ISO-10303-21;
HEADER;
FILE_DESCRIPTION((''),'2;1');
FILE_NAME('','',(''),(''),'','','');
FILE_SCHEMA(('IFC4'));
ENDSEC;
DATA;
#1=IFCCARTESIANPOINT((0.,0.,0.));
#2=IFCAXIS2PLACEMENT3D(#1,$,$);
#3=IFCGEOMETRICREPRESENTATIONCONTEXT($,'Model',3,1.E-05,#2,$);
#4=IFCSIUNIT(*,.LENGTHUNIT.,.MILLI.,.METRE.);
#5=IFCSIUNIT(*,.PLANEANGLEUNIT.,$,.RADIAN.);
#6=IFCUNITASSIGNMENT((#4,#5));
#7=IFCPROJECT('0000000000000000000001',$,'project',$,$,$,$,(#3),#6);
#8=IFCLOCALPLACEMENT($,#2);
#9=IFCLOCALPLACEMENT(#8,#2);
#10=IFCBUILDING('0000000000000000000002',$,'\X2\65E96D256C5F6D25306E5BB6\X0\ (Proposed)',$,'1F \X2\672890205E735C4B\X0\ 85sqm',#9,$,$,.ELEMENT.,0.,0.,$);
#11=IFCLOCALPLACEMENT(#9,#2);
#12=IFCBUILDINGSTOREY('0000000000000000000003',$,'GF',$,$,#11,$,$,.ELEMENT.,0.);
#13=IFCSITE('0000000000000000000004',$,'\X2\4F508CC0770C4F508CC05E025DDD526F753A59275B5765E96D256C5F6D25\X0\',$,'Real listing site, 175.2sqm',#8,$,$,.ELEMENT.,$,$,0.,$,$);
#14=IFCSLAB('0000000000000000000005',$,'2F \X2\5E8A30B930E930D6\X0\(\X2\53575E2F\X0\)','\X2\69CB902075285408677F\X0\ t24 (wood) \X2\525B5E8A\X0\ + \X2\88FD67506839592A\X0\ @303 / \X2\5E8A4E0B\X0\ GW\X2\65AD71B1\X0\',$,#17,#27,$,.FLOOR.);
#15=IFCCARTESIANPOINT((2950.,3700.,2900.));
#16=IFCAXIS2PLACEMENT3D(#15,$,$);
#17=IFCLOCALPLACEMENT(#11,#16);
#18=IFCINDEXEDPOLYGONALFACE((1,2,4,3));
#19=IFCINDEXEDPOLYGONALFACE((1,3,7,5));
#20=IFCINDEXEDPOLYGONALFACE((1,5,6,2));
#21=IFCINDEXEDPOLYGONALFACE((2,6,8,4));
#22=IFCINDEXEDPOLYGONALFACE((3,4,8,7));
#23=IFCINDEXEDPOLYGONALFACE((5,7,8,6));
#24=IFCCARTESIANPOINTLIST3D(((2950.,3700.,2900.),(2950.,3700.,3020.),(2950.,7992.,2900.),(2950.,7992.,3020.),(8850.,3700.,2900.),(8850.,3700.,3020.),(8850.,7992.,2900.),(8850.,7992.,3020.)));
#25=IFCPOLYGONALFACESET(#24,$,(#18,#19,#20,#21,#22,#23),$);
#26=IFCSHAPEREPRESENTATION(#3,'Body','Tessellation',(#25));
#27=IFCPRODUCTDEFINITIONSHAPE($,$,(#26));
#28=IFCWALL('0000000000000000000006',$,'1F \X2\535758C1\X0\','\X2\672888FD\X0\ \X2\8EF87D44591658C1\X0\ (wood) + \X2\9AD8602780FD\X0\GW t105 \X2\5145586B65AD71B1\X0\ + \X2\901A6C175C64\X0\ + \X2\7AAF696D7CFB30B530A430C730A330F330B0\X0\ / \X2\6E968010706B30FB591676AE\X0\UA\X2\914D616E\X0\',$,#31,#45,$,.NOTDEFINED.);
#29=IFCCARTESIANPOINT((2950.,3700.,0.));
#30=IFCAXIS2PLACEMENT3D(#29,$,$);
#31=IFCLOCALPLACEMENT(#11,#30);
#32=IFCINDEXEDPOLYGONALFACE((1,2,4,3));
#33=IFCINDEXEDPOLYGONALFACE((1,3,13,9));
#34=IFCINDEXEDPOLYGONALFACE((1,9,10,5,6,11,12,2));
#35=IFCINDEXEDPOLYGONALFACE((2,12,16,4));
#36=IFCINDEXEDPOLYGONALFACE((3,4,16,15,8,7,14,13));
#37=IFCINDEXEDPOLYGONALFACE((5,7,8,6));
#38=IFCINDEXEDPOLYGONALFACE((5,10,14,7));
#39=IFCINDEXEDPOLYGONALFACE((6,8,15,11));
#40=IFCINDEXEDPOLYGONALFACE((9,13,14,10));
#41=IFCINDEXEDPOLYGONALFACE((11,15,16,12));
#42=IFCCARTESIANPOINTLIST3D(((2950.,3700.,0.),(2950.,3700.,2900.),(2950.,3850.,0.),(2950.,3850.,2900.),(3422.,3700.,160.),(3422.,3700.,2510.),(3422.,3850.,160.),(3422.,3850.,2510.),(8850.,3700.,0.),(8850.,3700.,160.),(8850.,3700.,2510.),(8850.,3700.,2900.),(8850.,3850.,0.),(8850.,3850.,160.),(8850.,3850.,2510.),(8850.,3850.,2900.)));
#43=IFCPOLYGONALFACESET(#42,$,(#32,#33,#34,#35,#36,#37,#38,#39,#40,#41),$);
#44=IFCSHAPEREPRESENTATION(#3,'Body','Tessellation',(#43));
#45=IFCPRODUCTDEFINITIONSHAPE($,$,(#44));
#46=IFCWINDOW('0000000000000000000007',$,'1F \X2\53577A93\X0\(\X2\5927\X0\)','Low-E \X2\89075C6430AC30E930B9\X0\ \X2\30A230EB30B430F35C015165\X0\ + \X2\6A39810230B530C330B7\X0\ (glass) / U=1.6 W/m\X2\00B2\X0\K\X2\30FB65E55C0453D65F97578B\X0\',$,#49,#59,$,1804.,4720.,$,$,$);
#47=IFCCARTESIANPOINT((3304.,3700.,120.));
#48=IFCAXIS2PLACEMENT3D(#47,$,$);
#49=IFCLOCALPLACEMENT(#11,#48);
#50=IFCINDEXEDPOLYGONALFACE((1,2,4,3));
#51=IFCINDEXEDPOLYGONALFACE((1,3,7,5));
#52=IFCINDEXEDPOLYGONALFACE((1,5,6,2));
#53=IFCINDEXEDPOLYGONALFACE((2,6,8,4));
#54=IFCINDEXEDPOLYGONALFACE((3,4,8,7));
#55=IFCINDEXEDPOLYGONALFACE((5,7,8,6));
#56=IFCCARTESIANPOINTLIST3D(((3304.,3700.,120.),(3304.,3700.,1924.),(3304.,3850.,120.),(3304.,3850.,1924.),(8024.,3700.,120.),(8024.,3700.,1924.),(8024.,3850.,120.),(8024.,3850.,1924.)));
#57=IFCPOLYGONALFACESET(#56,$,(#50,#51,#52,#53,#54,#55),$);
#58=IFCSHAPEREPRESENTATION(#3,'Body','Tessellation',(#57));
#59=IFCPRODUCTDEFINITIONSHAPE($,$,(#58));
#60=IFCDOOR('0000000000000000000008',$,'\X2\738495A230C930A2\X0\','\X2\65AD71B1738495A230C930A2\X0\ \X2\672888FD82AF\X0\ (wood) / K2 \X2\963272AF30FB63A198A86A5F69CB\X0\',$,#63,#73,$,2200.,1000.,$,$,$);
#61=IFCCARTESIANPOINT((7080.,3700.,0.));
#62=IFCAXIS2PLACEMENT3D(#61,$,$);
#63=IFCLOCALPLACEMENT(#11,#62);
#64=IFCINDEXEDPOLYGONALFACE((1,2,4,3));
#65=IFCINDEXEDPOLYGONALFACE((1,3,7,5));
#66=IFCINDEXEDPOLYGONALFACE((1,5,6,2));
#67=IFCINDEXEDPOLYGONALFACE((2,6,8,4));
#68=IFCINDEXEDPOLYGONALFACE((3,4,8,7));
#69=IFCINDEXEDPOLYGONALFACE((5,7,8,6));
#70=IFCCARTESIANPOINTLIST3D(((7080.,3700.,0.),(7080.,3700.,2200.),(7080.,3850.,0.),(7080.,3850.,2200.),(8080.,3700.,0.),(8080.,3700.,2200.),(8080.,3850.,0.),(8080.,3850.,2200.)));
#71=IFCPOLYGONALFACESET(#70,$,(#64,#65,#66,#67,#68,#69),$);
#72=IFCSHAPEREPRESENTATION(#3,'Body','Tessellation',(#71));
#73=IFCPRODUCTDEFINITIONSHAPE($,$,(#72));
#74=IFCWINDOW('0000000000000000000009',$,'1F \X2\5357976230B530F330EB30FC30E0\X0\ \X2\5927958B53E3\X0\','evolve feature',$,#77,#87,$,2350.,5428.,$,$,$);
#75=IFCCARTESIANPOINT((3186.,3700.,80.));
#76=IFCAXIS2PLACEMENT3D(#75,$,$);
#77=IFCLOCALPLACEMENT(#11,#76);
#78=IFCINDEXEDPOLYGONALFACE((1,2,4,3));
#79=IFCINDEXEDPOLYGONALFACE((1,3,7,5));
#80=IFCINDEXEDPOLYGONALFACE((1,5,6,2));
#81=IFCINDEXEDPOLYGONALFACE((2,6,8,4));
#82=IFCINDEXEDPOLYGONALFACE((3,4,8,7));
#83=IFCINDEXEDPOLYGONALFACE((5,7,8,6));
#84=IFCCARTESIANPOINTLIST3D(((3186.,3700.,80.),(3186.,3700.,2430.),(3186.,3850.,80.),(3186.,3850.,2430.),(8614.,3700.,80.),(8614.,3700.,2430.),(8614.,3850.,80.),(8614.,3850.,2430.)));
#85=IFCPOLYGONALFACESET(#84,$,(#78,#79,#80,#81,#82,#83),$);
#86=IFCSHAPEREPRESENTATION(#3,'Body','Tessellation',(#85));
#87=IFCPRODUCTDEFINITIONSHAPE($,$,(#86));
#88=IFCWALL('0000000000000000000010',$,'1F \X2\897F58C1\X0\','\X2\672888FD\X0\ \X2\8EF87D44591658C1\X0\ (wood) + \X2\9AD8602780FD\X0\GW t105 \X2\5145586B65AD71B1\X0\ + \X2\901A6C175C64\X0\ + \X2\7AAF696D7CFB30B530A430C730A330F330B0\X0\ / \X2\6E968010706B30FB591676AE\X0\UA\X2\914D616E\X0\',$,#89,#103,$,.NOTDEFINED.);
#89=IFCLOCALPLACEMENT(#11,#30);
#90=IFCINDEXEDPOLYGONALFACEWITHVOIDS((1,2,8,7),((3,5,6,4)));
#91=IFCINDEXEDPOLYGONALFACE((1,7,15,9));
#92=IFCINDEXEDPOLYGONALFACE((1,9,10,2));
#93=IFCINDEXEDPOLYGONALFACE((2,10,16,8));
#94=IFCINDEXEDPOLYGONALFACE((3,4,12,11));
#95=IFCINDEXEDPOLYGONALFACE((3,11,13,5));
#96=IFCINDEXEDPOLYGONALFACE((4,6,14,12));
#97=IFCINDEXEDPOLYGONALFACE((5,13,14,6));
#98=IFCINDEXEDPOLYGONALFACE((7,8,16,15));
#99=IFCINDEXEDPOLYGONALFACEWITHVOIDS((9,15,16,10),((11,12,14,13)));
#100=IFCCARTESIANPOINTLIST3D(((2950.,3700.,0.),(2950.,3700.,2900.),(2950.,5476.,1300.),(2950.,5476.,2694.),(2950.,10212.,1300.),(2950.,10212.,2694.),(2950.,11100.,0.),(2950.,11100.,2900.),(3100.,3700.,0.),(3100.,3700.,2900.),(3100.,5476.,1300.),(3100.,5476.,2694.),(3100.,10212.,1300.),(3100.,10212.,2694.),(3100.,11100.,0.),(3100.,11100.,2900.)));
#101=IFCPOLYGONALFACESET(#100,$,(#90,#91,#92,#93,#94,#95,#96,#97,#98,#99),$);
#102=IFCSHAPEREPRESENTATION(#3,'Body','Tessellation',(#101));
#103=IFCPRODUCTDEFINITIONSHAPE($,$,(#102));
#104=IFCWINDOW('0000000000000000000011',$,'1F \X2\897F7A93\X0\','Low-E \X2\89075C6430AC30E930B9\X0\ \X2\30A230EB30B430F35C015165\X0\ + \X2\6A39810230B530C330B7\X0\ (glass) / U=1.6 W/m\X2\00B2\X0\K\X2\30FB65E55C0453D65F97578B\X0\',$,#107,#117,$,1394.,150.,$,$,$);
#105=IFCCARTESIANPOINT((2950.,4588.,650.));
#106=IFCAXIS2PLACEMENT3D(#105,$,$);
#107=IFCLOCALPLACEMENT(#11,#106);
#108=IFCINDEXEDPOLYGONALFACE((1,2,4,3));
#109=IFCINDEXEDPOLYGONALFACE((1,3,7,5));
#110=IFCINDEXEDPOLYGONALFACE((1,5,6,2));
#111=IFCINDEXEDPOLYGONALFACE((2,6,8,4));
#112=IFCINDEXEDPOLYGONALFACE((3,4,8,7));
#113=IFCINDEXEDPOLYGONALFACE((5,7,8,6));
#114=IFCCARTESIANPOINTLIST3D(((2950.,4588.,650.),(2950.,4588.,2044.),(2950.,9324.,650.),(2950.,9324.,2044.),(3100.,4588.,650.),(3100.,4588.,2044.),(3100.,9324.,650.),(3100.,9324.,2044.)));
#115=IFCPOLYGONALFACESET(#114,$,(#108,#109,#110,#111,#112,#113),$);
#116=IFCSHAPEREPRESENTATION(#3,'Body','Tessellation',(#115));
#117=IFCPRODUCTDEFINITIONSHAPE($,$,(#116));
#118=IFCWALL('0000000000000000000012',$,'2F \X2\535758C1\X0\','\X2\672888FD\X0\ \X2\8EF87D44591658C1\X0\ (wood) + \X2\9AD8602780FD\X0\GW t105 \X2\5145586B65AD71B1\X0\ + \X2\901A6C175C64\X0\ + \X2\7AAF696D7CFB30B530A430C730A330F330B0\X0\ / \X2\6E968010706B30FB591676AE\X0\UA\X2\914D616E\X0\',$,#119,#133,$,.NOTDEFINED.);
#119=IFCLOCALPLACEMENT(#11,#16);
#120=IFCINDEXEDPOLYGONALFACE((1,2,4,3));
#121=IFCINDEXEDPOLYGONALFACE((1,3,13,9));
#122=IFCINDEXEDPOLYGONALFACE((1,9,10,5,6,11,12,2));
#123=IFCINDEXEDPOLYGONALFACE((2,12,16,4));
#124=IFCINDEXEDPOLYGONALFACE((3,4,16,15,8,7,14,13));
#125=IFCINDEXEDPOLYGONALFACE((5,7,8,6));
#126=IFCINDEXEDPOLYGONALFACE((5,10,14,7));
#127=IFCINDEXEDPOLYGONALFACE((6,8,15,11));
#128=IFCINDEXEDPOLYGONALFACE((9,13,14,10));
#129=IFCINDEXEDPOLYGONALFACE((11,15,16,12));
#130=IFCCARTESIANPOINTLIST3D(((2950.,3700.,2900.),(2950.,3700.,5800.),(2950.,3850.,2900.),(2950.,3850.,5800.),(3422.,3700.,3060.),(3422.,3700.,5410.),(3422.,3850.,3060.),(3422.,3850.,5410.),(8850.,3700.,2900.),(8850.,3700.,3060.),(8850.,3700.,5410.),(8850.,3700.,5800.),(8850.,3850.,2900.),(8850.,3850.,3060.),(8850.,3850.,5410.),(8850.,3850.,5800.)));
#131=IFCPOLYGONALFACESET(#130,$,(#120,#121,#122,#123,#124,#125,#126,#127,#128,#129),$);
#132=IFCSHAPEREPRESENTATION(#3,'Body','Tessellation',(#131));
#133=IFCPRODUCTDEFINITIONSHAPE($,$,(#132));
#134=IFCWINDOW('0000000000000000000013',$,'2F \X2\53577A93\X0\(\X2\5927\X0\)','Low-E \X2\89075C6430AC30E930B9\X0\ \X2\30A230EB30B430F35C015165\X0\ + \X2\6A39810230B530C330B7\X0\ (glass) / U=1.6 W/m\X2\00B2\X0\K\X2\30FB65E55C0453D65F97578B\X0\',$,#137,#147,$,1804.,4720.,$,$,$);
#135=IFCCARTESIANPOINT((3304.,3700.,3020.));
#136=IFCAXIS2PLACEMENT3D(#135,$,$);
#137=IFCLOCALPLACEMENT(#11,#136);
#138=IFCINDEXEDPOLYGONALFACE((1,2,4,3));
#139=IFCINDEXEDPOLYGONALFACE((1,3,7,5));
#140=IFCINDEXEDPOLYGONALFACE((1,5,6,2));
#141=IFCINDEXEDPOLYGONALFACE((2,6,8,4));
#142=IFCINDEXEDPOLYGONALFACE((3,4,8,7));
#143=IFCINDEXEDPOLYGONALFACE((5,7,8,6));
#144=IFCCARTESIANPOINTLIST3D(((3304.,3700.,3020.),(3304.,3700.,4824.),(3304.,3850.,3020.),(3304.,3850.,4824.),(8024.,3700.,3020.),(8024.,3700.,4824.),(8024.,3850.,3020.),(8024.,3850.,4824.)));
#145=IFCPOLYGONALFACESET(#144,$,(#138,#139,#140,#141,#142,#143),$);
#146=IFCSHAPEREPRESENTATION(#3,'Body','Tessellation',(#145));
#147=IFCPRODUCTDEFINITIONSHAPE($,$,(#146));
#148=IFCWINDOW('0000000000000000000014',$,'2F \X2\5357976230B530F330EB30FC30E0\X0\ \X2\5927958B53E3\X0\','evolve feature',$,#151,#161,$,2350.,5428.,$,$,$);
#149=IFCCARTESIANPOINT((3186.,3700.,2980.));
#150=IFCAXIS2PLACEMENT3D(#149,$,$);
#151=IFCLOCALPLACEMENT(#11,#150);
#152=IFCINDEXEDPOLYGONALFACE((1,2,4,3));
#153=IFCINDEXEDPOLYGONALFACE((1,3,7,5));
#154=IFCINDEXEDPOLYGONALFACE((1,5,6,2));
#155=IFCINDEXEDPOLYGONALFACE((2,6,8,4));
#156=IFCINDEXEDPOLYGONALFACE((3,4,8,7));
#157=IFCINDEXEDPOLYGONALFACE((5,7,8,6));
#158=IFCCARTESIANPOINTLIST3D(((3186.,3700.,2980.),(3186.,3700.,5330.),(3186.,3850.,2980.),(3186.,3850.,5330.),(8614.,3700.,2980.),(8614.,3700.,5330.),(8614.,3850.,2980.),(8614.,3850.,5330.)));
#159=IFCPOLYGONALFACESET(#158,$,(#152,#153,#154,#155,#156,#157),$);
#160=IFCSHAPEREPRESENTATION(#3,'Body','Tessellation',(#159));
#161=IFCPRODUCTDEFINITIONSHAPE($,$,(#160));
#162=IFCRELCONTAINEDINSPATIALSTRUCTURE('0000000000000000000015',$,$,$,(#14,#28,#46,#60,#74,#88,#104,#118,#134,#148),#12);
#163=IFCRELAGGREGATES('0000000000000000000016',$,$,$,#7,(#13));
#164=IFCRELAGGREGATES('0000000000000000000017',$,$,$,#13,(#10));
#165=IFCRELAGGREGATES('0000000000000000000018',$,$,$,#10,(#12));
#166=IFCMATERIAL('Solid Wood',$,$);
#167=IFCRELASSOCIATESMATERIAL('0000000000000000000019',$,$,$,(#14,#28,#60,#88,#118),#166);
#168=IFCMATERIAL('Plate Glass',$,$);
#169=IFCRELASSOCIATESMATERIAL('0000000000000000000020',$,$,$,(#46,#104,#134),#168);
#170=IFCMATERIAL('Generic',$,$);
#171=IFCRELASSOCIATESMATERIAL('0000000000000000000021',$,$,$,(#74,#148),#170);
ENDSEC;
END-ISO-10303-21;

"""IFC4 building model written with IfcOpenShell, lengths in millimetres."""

from ifc_helpers import new_model, si_unit, frame, frame_2d, origin, place, context, project, spatial, rectangle, extrude, material, element, fill, save


model = new_model("IFC4")

# Units and contexts
model_context = context("Model", 3, precision=1e-05, world=origin())
ifc_project = project(units=[si_unit("LENGTHUNIT", "METRE", prefix="MILLI"), si_unit("PLANEANGLEUNIT", "RADIAN")], contexts=[model_context])

# Site, building, storey
site_placement = place(None, origin())
site = spatial("IfcSite", under=ifc_project, at=site_placement, Name="佐賀県佐賀市川副町大字早津江津", ObjectType="Real listing site, 175.2sqm", CompositionType="ELEMENT", RefElevation=0.0)
building_placement = place(site_placement, origin())
building = spatial("IfcBuilding", under=site, at=building_placement, Name="早津江津の家 (Proposed)", ObjectType="1F 木造平屋 85sqm", CompositionType="ELEMENT", ElevationOfRefHeight=0.0, ElevationOfTerrain=0.0)
storey_placement = place(building_placement, origin())
storey = spatial("IfcBuildingStorey", under=building, at=storey_placement, Name="GF", CompositionType="ELEMENT", Elevation=0.0)

# Slab
ifc_material_1 = material(Name="Solid Wood")
slab_1_placement = place(storey_placement, frame((2950.0, 3700.0, 2900.0)))
element("IfcSlab", 1, at=slab_1_placement, inside=storey, material=ifc_material_1, Name="2F 床スラブ(南帯)", Description="構造用合板 t24 (wood) 剛床 + 製材根太 @303 / 床下 GW断熱", PredefinedType="FLOOR", context=model_context, shape_type="SweptSolid", body=[
    extrude(rectangle(XDim=5900.0, YDim=4292.0, at=frame_2d((2950.0, 2146.0))), frame((2950.0, 3700.0, 2900.0)), (0.0, 0.0, 1.0), 120.0),
])
ifc_material_2 = material(Name="Generic")

# Wall, openings, windows, door
wall_1_placement = place(storey_placement, frame((2950.0, 3700.0, 0.0)))
wall_1 = element("IfcWall", 2, at=wall_1_placement, inside=storey, material=ifc_material_1, Name="1F 南壁", Description="木製 軸組外壁 (wood) + 高性能GW t105 充填断熱 + 通気層 + 窯業系サイディング / 準耐火・外皮UA配慮", PredefinedType="NOTDEFINED", context=model_context, shape_type="SweptSolid", body=[
    extrude(rectangle(XDim=5900.0, YDim=150.0, at=frame_2d((2950.0, 75.0))), frame((2950.0, 3700.0, 0.0)), (0.0, 0.0, 1.0), 2900.0),
])
opening_1_placement = place(storey_placement, frame((3304.0, 3700.0, 120.0)))
opening_1 = element("IfcOpeningElement", 3, at=opening_1_placement, cuts=wall_1, PredefinedType="NOTDEFINED", context=model_context, shape_type="SweptSolid", body=[
    extrude(rectangle(XDim=4720.0, YDim=150.0, at=frame_2d((2360.0, 75.0))), frame((3304.0, 3700.0, 120.0)), (0.0, 0.0, 1.0), 1804.0),
])
opening_2_placement = place(storey_placement, frame((7080.0, 3700.0, 0.0)))
opening_2 = element("IfcOpeningElement", 4, at=opening_2_placement, cuts=wall_1, PredefinedType="NOTDEFINED", context=model_context, shape_type="SweptSolid", body=[
    extrude(rectangle(XDim=1000.0, YDim=150.0, at=frame_2d((500.0, 75.0))), frame((7080.0, 3700.0, 0.0)), (0.0, 0.0, 1.0), 2200.0),
])
opening_3_placement = place(storey_placement, frame((3186.0, 3700.0, 80.0)))
opening_3 = element("IfcOpeningElement", 5, at=opening_3_placement, cuts=wall_1, PredefinedType="NOTDEFINED", context=model_context, shape_type="SweptSolid", body=[
    extrude(rectangle(XDim=5428.0, YDim=150.0, at=frame_2d((2714.0, 75.0))), frame((3186.0, 3700.0, 80.0)), (0.0, 0.0, 1.0), 2350.0),
])
ifc_material_3 = material(Name="Plate Glass")
window_1_placement = place(storey_placement, frame((3304.0, 3700.0, 120.0)))
window_1 = element("IfcWindow", 6, at=window_1_placement, inside=storey, material=ifc_material_3, Name="1F 南窓(大)", Description="Low-E 複層ガラス アルゴン封入 + 樹脂サッシ (glass) / U=1.6 W/m²K・日射取得型", OverallHeight=1804.0, OverallWidth=4720.0, context=model_context, shape_type="SweptSolid", body=[
    extrude(rectangle(XDim=4720.0, YDim=150.0, at=frame_2d((2360.0, 75.0))), frame((3304.0, 3700.0, 120.0)), (0.0, 0.0, 1.0), 1804.0),
])
fill(opening_1, window_1)
door_placement = place(storey_placement, frame((7080.0, 3700.0, 0.0)))
door = element("IfcDoor", 7, at=door_placement, inside=storey, material=ifc_material_1, Name="玄関ドア", Description="断熱玄関ドア 木製芯 (wood) / K2 防犯・採風機構", OverallHeight=2200.0, OverallWidth=1000.0, context=model_context, shape_type="SweptSolid", body=[
    extrude(rectangle(XDim=1000.0, YDim=150.0, at=frame_2d((500.0, 75.0))), frame((7080.0, 3700.0, 0.0)), (0.0, 0.0, 1.0), 2200.0),
])
fill(opening_2, door)
window_2_placement = place(storey_placement, frame((3186.0, 3700.0, 80.0)))
window_2 = element("IfcWindow", 8, at=window_2_placement, inside=storey, material=ifc_material_2, Name="1F 南面サンルーム 大開口", Description="evolve feature", OverallHeight=2350.0, OverallWidth=5428.0, context=model_context, shape_type="SweptSolid", body=[
    extrude(rectangle(XDim=5428.0, YDim=150.0, at=frame_2d((2714.0, 75.0))), frame((3186.0, 3700.0, 80.0)), (0.0, 0.0, 1.0), 2350.0),
])
fill(opening_3, window_2)

# Wall, opening, window
wall_2_placement = place(storey_placement, frame((2950.0, 3700.0, 0.0)))
wall_2 = element("IfcWall", 9, at=wall_2_placement, inside=storey, material=ifc_material_1, Name="1F 西壁", Description="木製 軸組外壁 (wood) + 高性能GW t105 充填断熱 + 通気層 + 窯業系サイディング / 準耐火・外皮UA配慮", PredefinedType="NOTDEFINED", context=model_context, shape_type="SweptSolid", body=[
    extrude(rectangle(XDim=150.0, YDim=7400.0, at=frame_2d((75.0, 3700.0))), frame((2950.0, 3700.0, 0.0)), (0.0, 0.0, 1.0), 2900.0),
])
opening_4_placement = place(storey_placement, frame((2950.0, 4588.0, 650.0)))
opening_4 = element("IfcOpeningElement", 10, at=opening_4_placement, cuts=wall_2, PredefinedType="NOTDEFINED", context=model_context, shape_type="SweptSolid", body=[
    extrude(rectangle(XDim=150.0, YDim=4736.0, at=frame_2d((75.0, 2368.0))), frame((2950.0, 4588.0, 650.0)), (0.0, 0.0, 1.0), 1394.0),
])
window_3_placement = place(storey_placement, frame((2950.0, 4588.0, 650.0)))
window_3 = element("IfcWindow", 11, at=window_3_placement, inside=storey, material=ifc_material_3, Name="1F 西窓", Description="Low-E 複層ガラス アルゴン封入 + 樹脂サッシ (glass) / U=1.6 W/m²K・日射取得型", OverallHeight=1394.0, OverallWidth=150.0, context=model_context, shape_type="SweptSolid", body=[
    extrude(rectangle(XDim=150.0, YDim=4736.0, at=frame_2d((75.0, 2368.0))), frame((2950.0, 4588.0, 650.0)), (0.0, 0.0, 1.0), 1394.0),
])
fill(opening_4, window_3)

# Wall, openings, windows
wall_3_placement = place(storey_placement, frame((2950.0, 3700.0, 2900.0)))
wall_3 = element("IfcWall", 12, at=wall_3_placement, inside=storey, material=ifc_material_1, Name="2F 南壁", Description="木製 軸組外壁 (wood) + 高性能GW t105 充填断熱 + 通気層 + 窯業系サイディング / 準耐火・外皮UA配慮", PredefinedType="NOTDEFINED", context=model_context, shape_type="SweptSolid", body=[
    extrude(rectangle(XDim=5900.0, YDim=150.0, at=frame_2d((2950.0, 75.0))), frame((2950.0, 3700.0, 2900.0)), (0.0, 0.0, 1.0), 2900.0),
])
opening_5_placement = place(storey_placement, frame((3304.0, 3700.0, 3020.0)))
opening_5 = element("IfcOpeningElement", 13, at=opening_5_placement, cuts=wall_3, PredefinedType="NOTDEFINED", context=model_context, shape_type="SweptSolid", body=[
    extrude(rectangle(XDim=4720.0, YDim=150.0, at=frame_2d((2360.0, 75.0))), frame((3304.0, 3700.0, 3020.0)), (0.0, 0.0, 1.0), 1804.0),
])
opening_6_placement = place(storey_placement, frame((3186.0, 3700.0, 2980.0)))
opening_6 = element("IfcOpeningElement", 14, at=opening_6_placement, cuts=wall_3, PredefinedType="NOTDEFINED", context=model_context, shape_type="SweptSolid", body=[
    extrude(rectangle(XDim=5428.0, YDim=150.0, at=frame_2d((2714.0, 75.0))), frame((3186.0, 3700.0, 2980.0)), (0.0, 0.0, 1.0), 2350.0),
])
window_4_placement = place(storey_placement, frame((3304.0, 3700.0, 3020.0)))
window_4 = element("IfcWindow", 15, at=window_4_placement, inside=storey, material=ifc_material_3, Name="2F 南窓(大)", Description="Low-E 複層ガラス アルゴン封入 + 樹脂サッシ (glass) / U=1.6 W/m²K・日射取得型", OverallHeight=1804.0, OverallWidth=4720.0, context=model_context, shape_type="SweptSolid", body=[
    extrude(rectangle(XDim=4720.0, YDim=150.0, at=frame_2d((2360.0, 75.0))), frame((3304.0, 3700.0, 3020.0)), (0.0, 0.0, 1.0), 1804.0),
])
fill(opening_5, window_4)
window_5_placement = place(storey_placement, frame((3186.0, 3700.0, 2980.0)))
window_5 = element("IfcWindow", 16, at=window_5_placement, inside=storey, material=ifc_material_2, Name="2F 南面サンルーム 大開口", Description="evolve feature", OverallHeight=2350.0, OverallWidth=5428.0, context=model_context, shape_type="SweptSolid", body=[
    extrude(rectangle(XDim=5428.0, YDim=150.0, at=frame_2d((2714.0, 75.0))), frame((3186.0, 3700.0, 2980.0)), (0.0, 0.0, 1.0), 2350.0),
])
fill(opening_6, window_5)

save(model, "model.ifc")
